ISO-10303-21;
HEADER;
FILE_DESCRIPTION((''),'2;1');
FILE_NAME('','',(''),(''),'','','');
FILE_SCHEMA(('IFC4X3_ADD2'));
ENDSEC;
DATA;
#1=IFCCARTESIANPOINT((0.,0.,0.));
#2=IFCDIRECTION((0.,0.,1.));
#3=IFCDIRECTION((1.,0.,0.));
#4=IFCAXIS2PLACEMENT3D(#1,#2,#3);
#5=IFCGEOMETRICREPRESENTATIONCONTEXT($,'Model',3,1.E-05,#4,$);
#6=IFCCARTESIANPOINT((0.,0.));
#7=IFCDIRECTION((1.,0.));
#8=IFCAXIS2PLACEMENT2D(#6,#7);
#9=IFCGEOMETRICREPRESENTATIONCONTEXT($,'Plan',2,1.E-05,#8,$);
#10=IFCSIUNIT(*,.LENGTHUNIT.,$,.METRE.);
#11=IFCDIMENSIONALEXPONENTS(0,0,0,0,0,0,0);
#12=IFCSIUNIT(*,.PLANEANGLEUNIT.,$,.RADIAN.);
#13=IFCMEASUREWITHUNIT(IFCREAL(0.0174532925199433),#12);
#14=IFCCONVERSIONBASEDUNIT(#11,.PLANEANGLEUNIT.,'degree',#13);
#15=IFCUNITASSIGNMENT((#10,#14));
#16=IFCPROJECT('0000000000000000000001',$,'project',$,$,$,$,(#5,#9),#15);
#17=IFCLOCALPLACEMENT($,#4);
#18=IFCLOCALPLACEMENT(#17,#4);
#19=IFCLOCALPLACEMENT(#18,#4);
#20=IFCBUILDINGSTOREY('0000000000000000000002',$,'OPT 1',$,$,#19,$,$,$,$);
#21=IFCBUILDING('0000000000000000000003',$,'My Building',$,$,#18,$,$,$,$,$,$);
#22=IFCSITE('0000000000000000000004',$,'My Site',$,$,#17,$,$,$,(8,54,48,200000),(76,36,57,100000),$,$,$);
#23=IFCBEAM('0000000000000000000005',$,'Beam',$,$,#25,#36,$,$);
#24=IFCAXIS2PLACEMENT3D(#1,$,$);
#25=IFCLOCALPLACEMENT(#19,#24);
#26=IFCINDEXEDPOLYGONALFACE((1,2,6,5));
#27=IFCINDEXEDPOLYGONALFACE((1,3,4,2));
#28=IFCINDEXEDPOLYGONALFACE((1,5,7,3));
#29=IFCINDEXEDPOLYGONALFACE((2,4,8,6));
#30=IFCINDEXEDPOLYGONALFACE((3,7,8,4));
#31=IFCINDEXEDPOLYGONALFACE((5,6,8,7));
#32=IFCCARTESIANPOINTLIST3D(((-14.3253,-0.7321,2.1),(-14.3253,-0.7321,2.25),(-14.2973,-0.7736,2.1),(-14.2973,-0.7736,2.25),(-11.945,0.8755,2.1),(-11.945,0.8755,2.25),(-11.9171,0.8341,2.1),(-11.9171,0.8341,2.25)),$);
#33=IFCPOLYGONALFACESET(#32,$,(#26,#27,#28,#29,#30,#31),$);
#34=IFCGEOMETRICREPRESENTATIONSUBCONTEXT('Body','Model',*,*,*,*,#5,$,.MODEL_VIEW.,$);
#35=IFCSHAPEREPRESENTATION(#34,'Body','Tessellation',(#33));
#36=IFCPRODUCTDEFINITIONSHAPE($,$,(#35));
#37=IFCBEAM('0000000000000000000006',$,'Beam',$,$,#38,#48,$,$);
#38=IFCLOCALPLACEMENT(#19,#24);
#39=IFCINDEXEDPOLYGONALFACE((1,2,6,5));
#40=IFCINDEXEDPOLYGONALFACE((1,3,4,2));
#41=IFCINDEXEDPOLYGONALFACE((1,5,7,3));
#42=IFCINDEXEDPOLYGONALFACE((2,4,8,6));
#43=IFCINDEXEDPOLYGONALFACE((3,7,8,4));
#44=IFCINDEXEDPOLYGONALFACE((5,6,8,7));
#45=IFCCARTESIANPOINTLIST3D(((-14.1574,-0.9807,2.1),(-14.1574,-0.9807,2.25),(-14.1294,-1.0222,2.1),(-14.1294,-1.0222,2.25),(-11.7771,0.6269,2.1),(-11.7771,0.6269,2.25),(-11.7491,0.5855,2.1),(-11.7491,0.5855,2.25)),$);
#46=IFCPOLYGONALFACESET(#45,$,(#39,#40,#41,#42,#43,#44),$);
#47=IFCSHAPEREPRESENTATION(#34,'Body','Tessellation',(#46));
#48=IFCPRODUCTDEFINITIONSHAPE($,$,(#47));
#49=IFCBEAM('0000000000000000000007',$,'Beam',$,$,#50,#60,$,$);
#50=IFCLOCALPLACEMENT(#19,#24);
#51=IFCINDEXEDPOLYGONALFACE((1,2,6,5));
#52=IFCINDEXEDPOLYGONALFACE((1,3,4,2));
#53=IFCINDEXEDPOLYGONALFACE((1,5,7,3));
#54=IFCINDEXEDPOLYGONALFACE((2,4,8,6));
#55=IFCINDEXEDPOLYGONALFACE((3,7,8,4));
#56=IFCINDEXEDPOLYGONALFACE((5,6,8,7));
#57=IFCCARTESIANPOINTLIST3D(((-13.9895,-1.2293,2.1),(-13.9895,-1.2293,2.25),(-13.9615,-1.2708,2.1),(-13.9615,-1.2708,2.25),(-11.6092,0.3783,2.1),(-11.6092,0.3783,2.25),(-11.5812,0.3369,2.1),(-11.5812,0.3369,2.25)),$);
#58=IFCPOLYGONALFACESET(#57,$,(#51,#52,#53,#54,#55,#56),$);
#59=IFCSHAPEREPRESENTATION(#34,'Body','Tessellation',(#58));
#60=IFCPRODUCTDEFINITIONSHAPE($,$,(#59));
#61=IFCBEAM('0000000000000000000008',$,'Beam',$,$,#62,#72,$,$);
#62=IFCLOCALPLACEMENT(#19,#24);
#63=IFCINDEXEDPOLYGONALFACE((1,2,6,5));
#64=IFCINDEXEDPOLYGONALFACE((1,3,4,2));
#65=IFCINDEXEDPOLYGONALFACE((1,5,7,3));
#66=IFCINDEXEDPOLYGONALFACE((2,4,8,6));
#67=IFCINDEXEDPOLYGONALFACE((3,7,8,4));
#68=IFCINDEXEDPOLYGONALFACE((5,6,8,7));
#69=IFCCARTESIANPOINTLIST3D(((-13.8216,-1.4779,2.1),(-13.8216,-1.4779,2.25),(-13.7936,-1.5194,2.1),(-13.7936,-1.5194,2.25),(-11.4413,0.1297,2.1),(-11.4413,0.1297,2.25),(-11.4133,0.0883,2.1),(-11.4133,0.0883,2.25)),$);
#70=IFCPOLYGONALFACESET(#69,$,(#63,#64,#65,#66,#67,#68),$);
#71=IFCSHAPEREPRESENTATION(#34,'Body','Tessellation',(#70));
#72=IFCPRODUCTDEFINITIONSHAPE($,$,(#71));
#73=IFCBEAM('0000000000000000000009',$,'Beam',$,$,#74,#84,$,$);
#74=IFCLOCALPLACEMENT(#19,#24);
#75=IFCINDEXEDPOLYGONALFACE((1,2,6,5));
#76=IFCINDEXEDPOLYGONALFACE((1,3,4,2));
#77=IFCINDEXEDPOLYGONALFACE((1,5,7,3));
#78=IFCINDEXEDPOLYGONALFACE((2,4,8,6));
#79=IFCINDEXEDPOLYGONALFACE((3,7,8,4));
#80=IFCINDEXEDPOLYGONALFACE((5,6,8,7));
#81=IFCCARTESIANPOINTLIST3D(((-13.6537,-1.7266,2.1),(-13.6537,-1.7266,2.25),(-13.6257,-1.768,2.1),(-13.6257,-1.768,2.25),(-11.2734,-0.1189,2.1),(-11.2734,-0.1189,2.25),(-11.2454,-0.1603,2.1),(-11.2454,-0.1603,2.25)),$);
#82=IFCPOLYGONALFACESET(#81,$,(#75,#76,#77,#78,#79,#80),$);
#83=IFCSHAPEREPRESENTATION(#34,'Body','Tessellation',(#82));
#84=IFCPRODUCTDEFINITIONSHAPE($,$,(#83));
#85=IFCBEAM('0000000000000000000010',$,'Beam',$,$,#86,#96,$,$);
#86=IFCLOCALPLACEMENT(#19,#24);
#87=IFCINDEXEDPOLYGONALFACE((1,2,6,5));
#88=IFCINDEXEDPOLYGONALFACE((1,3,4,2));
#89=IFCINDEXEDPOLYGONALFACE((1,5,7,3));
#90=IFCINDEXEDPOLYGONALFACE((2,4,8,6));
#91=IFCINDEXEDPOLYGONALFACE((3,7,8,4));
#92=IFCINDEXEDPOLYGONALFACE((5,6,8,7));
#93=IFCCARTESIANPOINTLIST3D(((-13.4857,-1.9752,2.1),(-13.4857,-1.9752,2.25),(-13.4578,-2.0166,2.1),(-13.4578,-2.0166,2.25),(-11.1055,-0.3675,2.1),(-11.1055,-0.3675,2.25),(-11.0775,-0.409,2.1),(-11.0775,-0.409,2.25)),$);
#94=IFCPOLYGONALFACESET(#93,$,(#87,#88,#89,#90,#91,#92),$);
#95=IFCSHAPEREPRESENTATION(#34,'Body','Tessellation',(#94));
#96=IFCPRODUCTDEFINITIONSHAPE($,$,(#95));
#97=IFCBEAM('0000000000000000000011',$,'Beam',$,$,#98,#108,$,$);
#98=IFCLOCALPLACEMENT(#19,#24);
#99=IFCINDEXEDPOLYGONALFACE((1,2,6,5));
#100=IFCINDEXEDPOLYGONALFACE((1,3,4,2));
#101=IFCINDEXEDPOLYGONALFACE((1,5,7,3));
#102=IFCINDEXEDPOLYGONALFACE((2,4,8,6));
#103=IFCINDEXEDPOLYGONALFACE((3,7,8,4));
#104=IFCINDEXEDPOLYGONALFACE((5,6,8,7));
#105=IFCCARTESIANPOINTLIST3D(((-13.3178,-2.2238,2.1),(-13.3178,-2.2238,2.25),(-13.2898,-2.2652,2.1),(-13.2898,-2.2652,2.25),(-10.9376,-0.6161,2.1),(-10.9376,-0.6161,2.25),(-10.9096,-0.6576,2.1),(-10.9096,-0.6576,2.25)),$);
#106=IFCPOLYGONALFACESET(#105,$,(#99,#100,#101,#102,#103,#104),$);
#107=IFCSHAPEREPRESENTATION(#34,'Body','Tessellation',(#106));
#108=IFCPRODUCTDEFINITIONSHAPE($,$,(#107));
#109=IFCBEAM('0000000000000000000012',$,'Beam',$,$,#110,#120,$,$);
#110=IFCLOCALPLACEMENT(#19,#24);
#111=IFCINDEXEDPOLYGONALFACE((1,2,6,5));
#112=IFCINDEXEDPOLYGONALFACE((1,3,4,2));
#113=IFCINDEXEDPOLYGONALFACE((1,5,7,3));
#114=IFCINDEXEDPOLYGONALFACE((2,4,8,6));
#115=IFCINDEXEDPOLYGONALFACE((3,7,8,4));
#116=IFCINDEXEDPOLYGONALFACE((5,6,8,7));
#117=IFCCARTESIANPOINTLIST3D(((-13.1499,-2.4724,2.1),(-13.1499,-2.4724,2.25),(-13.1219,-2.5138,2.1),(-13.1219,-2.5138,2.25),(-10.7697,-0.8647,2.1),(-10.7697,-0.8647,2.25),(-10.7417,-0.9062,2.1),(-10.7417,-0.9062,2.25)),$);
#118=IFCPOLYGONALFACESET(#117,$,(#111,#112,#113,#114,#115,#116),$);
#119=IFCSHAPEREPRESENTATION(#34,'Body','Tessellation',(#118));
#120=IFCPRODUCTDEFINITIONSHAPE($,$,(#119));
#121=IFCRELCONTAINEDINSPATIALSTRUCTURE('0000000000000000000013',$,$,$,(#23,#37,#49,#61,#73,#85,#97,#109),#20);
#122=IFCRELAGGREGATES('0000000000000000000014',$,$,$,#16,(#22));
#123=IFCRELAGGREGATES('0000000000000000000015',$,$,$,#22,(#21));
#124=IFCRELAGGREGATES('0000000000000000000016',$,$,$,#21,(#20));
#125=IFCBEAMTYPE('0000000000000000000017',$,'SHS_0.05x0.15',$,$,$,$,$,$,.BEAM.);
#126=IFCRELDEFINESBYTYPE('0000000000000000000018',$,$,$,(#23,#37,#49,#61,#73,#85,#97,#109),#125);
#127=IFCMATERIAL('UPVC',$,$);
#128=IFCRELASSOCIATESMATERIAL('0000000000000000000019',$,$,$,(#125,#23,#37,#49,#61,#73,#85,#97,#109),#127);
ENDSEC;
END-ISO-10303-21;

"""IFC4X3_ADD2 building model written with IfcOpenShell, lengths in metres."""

from ifc_helpers import new_model, entity, si_unit, converted_unit, frame, origin_with_axes, origin_2d_with_axis, place, context, subcontext, project, spatial, rectangle, extrude, material, material_profile, profile_set, profile_usage, type_object, element, save


model = new_model("IFC4X3_ADD2")

# Units and contexts
model_context = context("Model", 3, precision=1e-05, world=origin_with_axes())
plan_context = context("Plan", 2, precision=1e-05, world=origin_2d_with_axis())
body_context = subcontext(model_context, "Body", "Model", "MODEL_VIEW")
ifc_project = project(units=[si_unit("LENGTHUNIT", "METRE"), converted_unit("PLANEANGLEUNIT", "degree", entity("IfcReal", 0.0174532925199433), si_unit("PLANEANGLEUNIT", "RADIAN"), dimensions=[0, 0, 0, 0, 0, 0, 0])], contexts=[model_context, plan_context])

# Site, building, storey
site_placement = place(None, origin_with_axes())
site = spatial("IfcSite", under=ifc_project, at=site_placement, Name="My Site", RefLatitude=(8, 54, 48, 200000), RefLongitude=(76, 36, 57, 100000))
building_placement = place(site_placement, origin_with_axes())
building = spatial("IfcBuilding", under=site, at=building_placement, Name="My Building")
storey_placement = place(building_placement, origin_with_axes())
storey = spatial("IfcBuildingStorey", under=building, at=storey_placement, Name="OPT 1")

# Shared definitions
ifc_material_1 = material(Name="UPVC")

# Beams
ifc_material_profile_1 = material_profile(ifc_material_1, rectangle(XDim=0.05, YDim=0.15))
ifc_profile_set_1 = profile_set([ifc_material_profile_1])
beam_type = type_object("IfcBeamType", Name="SHS_0.05x0.15", PredefinedType="BEAM", material=ifc_profile_set_1)
ifc_profile_usage_1 = profile_usage(ifc_profile_set_1, cardinal=5)
beam_1_placement = place(storey_placement, frame((-11.931, 0.8548, 2.175), z_axis=(-0.828693, -0.559703, 0.0), x_axis=(0.559703, -0.828693, 0.0)))
element("IfcBeam", 1, at=beam_1_placement, inside=storey, type_object=beam_type, material=ifc_profile_usage_1, Name="Beam", context=body_context, shape_type="SweptSolid", body=[
    extrude(rectangle(XDim=0.05, YDim=0.15), origin_with_axes(), (0.0, 0.0, 1.0), 2.8723),
])
ifc_profile_usage_2 = profile_usage(ifc_profile_set_1, cardinal=5)
beam_2_placement = place(storey_placement, frame((-11.7631, 0.6062, 2.175), z_axis=(-0.828693, -0.559703, 0.0), x_axis=(0.559703, -0.828693, 0.0)))
element("IfcBeam", 2, at=beam_2_placement, inside=storey, type_object=beam_type, material=ifc_profile_usage_2, Name="Beam", context=body_context, shape_type="SweptSolid", body=[
    extrude(rectangle(XDim=0.05, YDim=0.15), origin_with_axes(), (0.0, 0.0, 1.0), 2.8723),
])
ifc_profile_usage_3 = profile_usage(ifc_profile_set_1, cardinal=5)
beam_3_placement = place(storey_placement, frame((-11.5952, 0.3576, 2.175), z_axis=(-0.828693, -0.559703, 0.0), x_axis=(0.559703, -0.828693, 0.0)))
element("IfcBeam", 3, at=beam_3_placement, inside=storey, type_object=beam_type, material=ifc_profile_usage_3, Name="Beam", context=body_context, shape_type="SweptSolid", body=[
    extrude(rectangle(XDim=0.05, YDim=0.15), origin_with_axes(), (0.0, 0.0, 1.0), 2.8723),
])
ifc_profile_usage_4 = profile_usage(ifc_profile_set_1, cardinal=5)
beam_4_placement = place(storey_placement, frame((-11.4273, 0.109, 2.175), z_axis=(-0.828693, -0.559703, 0.0), x_axis=(0.559703, -0.828693, 0.0)))
element("IfcBeam", 4, at=beam_4_placement, inside=storey, type_object=beam_type, material=ifc_profile_usage_4, Name="Beam", context=body_context, shape_type="SweptSolid", body=[
    extrude(rectangle(XDim=0.05, YDim=0.15), origin_with_axes(), (0.0, 0.0, 1.0), 2.8723),
])
ifc_profile_usage_5 = profile_usage(ifc_profile_set_1, cardinal=5)
beam_5_placement = place(storey_placement, frame((-11.2594, -0.1396, 2.175), z_axis=(-0.828693, -0.559703, 0.0), x_axis=(0.559703, -0.828693, 0.0)))
element("IfcBeam", 5, at=beam_5_placement, inside=storey, type_object=beam_type, material=ifc_profile_usage_5, Name="Beam", context=body_context, shape_type="SweptSolid", body=[
    extrude(rectangle(XDim=0.05, YDim=0.15), origin_with_axes(), (0.0, 0.0, 1.0), 2.8723),
])
ifc_profile_usage_6 = profile_usage(ifc_profile_set_1, cardinal=5)
beam_6_placement = place(storey_placement, frame((-11.0915, -0.3882, 2.175), z_axis=(-0.828693, -0.559703, 0.0), x_axis=(0.559703, -0.828693, 0.0)))
element("IfcBeam", 6, at=beam_6_placement, inside=storey, type_object=beam_type, material=ifc_profile_usage_6, Name="Beam", context=body_context, shape_type="SweptSolid", body=[
    extrude(rectangle(XDim=0.05, YDim=0.15), origin_with_axes(), (0.0, 0.0, 1.0), 2.8723),
])
ifc_profile_usage_7 = profile_usage(ifc_profile_set_1, cardinal=5)
beam_7_placement = place(storey_placement, frame((-10.9236, -0.6368, 2.175), z_axis=(-0.828693, -0.559703, 0.0), x_axis=(0.559703, -0.828693, 0.0)))
element("IfcBeam", 7, at=beam_7_placement, inside=storey, type_object=beam_type, material=ifc_profile_usage_7, Name="Beam", context=body_context, shape_type="SweptSolid", body=[
    extrude(rectangle(XDim=0.05, YDim=0.15), origin_with_axes(), (0.0, 0.0, 1.0), 2.8723),
])
ifc_profile_usage_8 = profile_usage(ifc_profile_set_1, cardinal=5)
beam_8_placement = place(storey_placement, frame((-10.7557, -0.8855, 2.175), z_axis=(-0.828693, -0.559703, 0.0), x_axis=(0.559703, -0.828693, 0.0)))
element("IfcBeam", 8, at=beam_8_placement, inside=storey, type_object=beam_type, material=ifc_profile_usage_8, Name="Beam", context=body_context, shape_type="SweptSolid", body=[
    extrude(rectangle(XDim=0.05, YDim=0.15), origin_with_axes(), (0.0, 0.0, 1.0), 2.8723),
])

save(model, "model.ifc")
